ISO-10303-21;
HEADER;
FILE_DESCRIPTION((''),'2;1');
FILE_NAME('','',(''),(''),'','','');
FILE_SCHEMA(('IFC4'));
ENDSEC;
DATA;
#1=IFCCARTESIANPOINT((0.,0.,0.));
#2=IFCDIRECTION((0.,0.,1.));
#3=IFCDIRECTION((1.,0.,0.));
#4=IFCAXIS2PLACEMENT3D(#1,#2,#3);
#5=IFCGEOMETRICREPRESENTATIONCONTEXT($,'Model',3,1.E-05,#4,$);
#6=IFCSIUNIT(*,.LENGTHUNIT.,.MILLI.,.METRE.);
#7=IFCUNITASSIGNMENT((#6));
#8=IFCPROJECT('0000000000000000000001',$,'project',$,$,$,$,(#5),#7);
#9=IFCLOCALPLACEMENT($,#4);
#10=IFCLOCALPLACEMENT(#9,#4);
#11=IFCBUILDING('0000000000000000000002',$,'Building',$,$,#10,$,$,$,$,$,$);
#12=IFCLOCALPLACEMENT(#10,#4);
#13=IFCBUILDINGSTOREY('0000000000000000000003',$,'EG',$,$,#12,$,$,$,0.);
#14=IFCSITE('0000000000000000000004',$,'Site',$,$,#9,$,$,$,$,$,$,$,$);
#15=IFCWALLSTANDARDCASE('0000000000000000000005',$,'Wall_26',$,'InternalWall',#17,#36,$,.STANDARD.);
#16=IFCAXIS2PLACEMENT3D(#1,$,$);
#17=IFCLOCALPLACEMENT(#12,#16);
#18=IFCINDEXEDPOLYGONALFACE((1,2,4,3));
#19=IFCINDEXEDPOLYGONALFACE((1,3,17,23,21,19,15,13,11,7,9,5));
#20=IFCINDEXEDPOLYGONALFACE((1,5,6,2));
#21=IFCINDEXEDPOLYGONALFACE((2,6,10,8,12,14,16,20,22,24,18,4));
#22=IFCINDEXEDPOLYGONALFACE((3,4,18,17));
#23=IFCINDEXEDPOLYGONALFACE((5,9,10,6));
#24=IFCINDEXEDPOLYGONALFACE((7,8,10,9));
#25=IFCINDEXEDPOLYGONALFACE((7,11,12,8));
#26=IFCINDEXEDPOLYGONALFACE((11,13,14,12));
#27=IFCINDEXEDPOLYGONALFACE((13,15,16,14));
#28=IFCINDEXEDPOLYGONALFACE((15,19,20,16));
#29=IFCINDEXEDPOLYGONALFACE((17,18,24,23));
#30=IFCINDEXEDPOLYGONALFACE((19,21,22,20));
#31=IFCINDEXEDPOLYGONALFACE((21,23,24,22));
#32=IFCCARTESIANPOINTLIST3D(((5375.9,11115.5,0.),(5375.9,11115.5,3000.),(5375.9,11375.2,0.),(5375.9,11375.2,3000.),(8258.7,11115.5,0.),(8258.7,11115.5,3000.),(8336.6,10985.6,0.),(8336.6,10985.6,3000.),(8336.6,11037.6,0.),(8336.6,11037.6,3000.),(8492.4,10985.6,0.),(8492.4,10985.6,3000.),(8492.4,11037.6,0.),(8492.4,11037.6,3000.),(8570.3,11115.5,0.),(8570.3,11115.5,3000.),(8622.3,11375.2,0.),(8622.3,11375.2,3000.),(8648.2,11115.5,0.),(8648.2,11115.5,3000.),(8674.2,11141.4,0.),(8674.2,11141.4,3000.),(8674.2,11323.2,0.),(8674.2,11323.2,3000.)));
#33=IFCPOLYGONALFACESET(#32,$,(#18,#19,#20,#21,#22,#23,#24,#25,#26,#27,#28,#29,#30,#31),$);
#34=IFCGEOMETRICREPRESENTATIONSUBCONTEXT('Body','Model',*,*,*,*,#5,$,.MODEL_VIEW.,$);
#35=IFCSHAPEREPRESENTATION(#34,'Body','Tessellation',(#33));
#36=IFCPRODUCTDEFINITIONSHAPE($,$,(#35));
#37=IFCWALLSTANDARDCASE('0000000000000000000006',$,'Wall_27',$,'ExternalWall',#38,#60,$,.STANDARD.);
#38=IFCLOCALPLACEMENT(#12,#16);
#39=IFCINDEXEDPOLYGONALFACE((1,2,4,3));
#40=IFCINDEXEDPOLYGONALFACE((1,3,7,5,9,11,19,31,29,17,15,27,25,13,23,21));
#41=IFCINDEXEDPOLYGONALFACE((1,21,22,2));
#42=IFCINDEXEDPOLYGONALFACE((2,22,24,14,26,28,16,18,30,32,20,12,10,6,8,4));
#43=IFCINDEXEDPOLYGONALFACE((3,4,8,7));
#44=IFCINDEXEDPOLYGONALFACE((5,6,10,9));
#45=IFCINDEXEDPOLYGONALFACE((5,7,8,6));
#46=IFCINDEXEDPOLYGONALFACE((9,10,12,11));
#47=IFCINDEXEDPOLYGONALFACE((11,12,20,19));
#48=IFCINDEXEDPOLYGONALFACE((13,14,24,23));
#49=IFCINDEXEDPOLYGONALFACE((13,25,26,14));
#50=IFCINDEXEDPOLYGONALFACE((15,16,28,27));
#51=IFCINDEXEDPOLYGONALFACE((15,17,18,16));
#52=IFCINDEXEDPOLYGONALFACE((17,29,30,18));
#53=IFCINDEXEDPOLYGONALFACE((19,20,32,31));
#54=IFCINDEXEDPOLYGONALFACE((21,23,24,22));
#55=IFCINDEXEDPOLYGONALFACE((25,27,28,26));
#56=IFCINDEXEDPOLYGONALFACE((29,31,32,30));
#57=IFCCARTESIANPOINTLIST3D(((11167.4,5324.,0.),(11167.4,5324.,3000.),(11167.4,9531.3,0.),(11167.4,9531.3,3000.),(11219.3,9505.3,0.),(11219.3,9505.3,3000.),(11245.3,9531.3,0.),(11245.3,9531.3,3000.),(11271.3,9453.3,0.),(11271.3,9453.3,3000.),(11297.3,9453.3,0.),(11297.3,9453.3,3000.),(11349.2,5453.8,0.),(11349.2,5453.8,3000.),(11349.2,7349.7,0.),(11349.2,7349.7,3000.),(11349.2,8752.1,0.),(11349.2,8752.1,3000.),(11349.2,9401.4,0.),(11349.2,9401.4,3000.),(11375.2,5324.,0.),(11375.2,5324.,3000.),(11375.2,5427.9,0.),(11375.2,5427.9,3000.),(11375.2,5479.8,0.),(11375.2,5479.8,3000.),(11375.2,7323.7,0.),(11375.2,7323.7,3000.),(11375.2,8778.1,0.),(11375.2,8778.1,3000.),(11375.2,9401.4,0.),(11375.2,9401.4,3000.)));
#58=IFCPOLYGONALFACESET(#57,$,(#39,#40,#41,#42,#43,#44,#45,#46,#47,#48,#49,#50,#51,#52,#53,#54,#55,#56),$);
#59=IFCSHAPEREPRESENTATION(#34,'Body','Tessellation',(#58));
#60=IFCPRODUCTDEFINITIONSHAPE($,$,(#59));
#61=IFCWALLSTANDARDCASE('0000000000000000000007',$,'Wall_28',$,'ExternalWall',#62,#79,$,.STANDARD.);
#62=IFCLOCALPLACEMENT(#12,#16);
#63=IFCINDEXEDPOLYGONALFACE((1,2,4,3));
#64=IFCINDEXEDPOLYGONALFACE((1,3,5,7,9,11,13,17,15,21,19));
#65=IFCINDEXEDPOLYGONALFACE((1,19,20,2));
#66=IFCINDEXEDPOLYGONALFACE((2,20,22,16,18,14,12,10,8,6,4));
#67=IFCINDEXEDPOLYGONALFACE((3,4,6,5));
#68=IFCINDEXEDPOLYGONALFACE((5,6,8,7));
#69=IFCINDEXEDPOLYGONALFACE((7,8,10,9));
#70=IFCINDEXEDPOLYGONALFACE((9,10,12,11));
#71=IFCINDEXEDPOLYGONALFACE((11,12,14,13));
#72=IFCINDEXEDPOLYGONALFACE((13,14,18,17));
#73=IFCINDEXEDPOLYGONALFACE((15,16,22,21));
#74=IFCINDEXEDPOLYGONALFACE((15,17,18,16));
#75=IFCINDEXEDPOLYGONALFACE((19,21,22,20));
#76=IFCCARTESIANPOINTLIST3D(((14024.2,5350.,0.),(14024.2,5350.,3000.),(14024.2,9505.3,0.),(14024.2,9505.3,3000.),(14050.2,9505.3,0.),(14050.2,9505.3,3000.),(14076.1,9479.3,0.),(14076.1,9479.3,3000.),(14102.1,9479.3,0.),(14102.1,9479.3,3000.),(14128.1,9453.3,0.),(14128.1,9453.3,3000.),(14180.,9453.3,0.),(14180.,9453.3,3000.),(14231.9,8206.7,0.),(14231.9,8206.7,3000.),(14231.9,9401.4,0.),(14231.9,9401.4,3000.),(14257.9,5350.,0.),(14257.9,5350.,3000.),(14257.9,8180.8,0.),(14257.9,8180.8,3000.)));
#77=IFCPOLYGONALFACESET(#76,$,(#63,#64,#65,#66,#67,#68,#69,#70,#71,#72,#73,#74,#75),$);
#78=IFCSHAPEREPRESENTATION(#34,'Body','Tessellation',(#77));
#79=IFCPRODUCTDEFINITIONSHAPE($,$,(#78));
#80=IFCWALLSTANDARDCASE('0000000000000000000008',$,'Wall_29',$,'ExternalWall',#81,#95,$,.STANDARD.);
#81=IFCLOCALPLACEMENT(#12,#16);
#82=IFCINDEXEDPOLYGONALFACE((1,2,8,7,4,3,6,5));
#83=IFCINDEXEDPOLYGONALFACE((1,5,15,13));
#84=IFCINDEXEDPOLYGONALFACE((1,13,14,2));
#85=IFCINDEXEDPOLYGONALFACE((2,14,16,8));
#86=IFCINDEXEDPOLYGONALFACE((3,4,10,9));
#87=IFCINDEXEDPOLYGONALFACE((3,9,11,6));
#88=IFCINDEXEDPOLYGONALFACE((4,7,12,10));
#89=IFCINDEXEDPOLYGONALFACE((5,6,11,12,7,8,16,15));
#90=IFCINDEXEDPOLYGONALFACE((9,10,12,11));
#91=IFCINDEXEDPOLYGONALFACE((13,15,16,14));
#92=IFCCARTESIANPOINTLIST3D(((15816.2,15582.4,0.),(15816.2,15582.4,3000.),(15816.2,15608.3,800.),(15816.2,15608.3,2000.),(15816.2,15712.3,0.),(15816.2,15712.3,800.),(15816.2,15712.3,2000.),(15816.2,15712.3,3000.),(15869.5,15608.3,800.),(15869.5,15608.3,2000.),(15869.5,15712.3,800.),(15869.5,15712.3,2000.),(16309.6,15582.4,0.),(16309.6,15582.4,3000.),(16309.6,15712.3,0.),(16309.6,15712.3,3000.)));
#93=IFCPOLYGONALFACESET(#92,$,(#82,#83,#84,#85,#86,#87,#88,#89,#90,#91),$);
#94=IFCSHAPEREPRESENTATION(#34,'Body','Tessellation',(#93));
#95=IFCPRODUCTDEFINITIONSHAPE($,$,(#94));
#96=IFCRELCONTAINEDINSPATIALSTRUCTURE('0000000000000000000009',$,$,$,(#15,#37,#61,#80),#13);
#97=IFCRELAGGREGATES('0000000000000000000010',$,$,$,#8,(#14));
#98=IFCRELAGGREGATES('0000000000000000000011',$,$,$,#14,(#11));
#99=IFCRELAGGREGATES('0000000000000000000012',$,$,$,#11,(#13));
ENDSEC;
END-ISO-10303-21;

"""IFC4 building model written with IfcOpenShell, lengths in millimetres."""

from ifc_helpers import new_model, si_unit, frame, origin_with_axes, place, context, subcontext, project, spatial, polyline, rectangle, outline, extrude, element, save


model = new_model("IFC4")

# Units and contexts
model_context = context("Model", 3, precision=1e-05, world=origin_with_axes())
body_context = subcontext(model_context, "Body", "Model", "MODEL_VIEW")
ifc_project = project(units=[si_unit("LENGTHUNIT", "METRE", prefix="MILLI")], contexts=[model_context])

# Site, building, storey
site_placement = place(None, origin_with_axes())
site = spatial("IfcSite", under=ifc_project, at=site_placement, Name="Site")
building_placement = place(site_placement, origin_with_axes())
building = spatial("IfcBuilding", under=site, at=building_placement, Name="Building")
storey_placement = place(building_placement, origin_with_axes())
storey = spatial("IfcBuildingStorey", under=building, at=storey_placement, Name="EG", Elevation=0.0)

# Walls
wall_1_placement = place(storey_placement, origin_with_axes())
element("IfcWallStandardCase", 1, at=wall_1_placement, inside=storey, Name="Wall_26", ObjectType="InternalWall", PredefinedType="STANDARD", context=body_context, shape_type="SweptSolid", body=[
    extrude(outline(polyline([(8336.6, 10985.6, 0.0), (8336.6, 11037.6, 0.0), (8258.7, 11115.5, 0.0), (5375.9, 11115.5, 0.0), (5375.9, 11375.2, 0.0), (8622.3, 11375.2, 0.0), (8674.2, 11323.2, 0.0), (8674.2, 11141.4, 0.0), (8648.2, 11115.5, 0.0), (8570.3, 11115.5, 0.0), (8492.4, 11037.6, 0.0), (8492.4, 10985.6, 0.0), (8336.6, 10985.6, 0.0)])), origin_with_axes(), (0.0, 0.0, 1.0), 3000.0),
])
wall_2_placement = place(storey_placement, origin_with_axes())
element("IfcWallStandardCase", 2, at=wall_2_placement, inside=storey, Name="Wall_27", ObjectType="ExternalWall", PredefinedType="STANDARD", context=body_context, shape_type="SweptSolid", body=[
    extrude(outline(polyline([(11167.4, 5324.0, 0.0), (11167.4, 9531.3, 0.0), (11245.3, 9531.3, 0.0), (11219.3, 9505.3, 0.0), (11271.3, 9453.3, 0.0), (11297.3, 9453.3, 0.0), (11349.2, 9401.4, 0.0), (11375.2, 9401.4, 0.0), (11375.2, 8778.1, 0.0), (11349.2, 8752.1, 0.0), (11349.2, 7349.7, 0.0), (11375.2, 7323.7, 0.0), (11375.2, 5479.8, 0.0), (11349.2, 5453.8, 0.0), (11375.2, 5427.9, 0.0), (11375.2, 5324.0, 0.0), (11167.4, 5324.0, 0.0)])), origin_with_axes(), (0.0, 0.0, 1.0), 3000.0),
])
wall_3_placement = place(storey_placement, origin_with_axes())
element("IfcWallStandardCase", 3, at=wall_3_placement, inside=storey, Name="Wall_28", ObjectType="ExternalWall", PredefinedType="STANDARD", context=body_context, shape_type="SweptSolid", body=[
    extrude(outline(polyline([(14024.2, 5350.0, 0.0), (14024.2, 9505.3, 0.0), (14050.2, 9505.3, 0.0), (14076.1, 9479.3, 0.0), (14102.1, 9479.3, 0.0), (14128.1, 9453.3, 0.0), (14180.0, 9453.3, 0.0), (14231.9, 9401.4, 0.0), (14231.9, 8206.7, 0.0), (14257.9, 8180.8, 0.0), (14257.9, 5350.0, 0.0), (14024.2, 5350.0, 0.0)])), origin_with_axes(), (0.0, 0.0, 1.0), 3000.0),
])

# Wall, opening
wall_4_placement = place(storey_placement, origin_with_axes())
wall_4 = element("IfcWallStandardCase", 4, at=wall_4_placement, inside=storey, Name="Wall_29", ObjectType="ExternalWall", PredefinedType="STANDARD", context=body_context, shape_type="SweptSolid", body=[
    extrude(outline(polyline([(15816.2, 15582.4, 0.0), (15816.2, 15712.3, 0.0), (16309.6, 15712.3, 0.0), (16309.6, 15582.4, 0.0), (15816.2, 15582.4, 0.0)])), origin_with_axes(), (0.0, 0.0, 1.0), 3000.0),
])
opening_1_placement = place(wall_4_placement, origin_with_axes())
element("IfcOpeningElement", 5, at=opening_1_placement, inside=storey, cuts=wall_4, context=body_context, shape_type="SweptSolid", body=[
    extrude(rectangle(XDim=1200.0, YDim=129.9), frame((15269.5, 15673.2, 800.0), z_axis=(0.0, 0.0, 1.0), x_axis=(1.0, 0.0, 0.0)), (0.0, 0.0, 1.0), 1200.0),
])

save(model, "model.ifc")
